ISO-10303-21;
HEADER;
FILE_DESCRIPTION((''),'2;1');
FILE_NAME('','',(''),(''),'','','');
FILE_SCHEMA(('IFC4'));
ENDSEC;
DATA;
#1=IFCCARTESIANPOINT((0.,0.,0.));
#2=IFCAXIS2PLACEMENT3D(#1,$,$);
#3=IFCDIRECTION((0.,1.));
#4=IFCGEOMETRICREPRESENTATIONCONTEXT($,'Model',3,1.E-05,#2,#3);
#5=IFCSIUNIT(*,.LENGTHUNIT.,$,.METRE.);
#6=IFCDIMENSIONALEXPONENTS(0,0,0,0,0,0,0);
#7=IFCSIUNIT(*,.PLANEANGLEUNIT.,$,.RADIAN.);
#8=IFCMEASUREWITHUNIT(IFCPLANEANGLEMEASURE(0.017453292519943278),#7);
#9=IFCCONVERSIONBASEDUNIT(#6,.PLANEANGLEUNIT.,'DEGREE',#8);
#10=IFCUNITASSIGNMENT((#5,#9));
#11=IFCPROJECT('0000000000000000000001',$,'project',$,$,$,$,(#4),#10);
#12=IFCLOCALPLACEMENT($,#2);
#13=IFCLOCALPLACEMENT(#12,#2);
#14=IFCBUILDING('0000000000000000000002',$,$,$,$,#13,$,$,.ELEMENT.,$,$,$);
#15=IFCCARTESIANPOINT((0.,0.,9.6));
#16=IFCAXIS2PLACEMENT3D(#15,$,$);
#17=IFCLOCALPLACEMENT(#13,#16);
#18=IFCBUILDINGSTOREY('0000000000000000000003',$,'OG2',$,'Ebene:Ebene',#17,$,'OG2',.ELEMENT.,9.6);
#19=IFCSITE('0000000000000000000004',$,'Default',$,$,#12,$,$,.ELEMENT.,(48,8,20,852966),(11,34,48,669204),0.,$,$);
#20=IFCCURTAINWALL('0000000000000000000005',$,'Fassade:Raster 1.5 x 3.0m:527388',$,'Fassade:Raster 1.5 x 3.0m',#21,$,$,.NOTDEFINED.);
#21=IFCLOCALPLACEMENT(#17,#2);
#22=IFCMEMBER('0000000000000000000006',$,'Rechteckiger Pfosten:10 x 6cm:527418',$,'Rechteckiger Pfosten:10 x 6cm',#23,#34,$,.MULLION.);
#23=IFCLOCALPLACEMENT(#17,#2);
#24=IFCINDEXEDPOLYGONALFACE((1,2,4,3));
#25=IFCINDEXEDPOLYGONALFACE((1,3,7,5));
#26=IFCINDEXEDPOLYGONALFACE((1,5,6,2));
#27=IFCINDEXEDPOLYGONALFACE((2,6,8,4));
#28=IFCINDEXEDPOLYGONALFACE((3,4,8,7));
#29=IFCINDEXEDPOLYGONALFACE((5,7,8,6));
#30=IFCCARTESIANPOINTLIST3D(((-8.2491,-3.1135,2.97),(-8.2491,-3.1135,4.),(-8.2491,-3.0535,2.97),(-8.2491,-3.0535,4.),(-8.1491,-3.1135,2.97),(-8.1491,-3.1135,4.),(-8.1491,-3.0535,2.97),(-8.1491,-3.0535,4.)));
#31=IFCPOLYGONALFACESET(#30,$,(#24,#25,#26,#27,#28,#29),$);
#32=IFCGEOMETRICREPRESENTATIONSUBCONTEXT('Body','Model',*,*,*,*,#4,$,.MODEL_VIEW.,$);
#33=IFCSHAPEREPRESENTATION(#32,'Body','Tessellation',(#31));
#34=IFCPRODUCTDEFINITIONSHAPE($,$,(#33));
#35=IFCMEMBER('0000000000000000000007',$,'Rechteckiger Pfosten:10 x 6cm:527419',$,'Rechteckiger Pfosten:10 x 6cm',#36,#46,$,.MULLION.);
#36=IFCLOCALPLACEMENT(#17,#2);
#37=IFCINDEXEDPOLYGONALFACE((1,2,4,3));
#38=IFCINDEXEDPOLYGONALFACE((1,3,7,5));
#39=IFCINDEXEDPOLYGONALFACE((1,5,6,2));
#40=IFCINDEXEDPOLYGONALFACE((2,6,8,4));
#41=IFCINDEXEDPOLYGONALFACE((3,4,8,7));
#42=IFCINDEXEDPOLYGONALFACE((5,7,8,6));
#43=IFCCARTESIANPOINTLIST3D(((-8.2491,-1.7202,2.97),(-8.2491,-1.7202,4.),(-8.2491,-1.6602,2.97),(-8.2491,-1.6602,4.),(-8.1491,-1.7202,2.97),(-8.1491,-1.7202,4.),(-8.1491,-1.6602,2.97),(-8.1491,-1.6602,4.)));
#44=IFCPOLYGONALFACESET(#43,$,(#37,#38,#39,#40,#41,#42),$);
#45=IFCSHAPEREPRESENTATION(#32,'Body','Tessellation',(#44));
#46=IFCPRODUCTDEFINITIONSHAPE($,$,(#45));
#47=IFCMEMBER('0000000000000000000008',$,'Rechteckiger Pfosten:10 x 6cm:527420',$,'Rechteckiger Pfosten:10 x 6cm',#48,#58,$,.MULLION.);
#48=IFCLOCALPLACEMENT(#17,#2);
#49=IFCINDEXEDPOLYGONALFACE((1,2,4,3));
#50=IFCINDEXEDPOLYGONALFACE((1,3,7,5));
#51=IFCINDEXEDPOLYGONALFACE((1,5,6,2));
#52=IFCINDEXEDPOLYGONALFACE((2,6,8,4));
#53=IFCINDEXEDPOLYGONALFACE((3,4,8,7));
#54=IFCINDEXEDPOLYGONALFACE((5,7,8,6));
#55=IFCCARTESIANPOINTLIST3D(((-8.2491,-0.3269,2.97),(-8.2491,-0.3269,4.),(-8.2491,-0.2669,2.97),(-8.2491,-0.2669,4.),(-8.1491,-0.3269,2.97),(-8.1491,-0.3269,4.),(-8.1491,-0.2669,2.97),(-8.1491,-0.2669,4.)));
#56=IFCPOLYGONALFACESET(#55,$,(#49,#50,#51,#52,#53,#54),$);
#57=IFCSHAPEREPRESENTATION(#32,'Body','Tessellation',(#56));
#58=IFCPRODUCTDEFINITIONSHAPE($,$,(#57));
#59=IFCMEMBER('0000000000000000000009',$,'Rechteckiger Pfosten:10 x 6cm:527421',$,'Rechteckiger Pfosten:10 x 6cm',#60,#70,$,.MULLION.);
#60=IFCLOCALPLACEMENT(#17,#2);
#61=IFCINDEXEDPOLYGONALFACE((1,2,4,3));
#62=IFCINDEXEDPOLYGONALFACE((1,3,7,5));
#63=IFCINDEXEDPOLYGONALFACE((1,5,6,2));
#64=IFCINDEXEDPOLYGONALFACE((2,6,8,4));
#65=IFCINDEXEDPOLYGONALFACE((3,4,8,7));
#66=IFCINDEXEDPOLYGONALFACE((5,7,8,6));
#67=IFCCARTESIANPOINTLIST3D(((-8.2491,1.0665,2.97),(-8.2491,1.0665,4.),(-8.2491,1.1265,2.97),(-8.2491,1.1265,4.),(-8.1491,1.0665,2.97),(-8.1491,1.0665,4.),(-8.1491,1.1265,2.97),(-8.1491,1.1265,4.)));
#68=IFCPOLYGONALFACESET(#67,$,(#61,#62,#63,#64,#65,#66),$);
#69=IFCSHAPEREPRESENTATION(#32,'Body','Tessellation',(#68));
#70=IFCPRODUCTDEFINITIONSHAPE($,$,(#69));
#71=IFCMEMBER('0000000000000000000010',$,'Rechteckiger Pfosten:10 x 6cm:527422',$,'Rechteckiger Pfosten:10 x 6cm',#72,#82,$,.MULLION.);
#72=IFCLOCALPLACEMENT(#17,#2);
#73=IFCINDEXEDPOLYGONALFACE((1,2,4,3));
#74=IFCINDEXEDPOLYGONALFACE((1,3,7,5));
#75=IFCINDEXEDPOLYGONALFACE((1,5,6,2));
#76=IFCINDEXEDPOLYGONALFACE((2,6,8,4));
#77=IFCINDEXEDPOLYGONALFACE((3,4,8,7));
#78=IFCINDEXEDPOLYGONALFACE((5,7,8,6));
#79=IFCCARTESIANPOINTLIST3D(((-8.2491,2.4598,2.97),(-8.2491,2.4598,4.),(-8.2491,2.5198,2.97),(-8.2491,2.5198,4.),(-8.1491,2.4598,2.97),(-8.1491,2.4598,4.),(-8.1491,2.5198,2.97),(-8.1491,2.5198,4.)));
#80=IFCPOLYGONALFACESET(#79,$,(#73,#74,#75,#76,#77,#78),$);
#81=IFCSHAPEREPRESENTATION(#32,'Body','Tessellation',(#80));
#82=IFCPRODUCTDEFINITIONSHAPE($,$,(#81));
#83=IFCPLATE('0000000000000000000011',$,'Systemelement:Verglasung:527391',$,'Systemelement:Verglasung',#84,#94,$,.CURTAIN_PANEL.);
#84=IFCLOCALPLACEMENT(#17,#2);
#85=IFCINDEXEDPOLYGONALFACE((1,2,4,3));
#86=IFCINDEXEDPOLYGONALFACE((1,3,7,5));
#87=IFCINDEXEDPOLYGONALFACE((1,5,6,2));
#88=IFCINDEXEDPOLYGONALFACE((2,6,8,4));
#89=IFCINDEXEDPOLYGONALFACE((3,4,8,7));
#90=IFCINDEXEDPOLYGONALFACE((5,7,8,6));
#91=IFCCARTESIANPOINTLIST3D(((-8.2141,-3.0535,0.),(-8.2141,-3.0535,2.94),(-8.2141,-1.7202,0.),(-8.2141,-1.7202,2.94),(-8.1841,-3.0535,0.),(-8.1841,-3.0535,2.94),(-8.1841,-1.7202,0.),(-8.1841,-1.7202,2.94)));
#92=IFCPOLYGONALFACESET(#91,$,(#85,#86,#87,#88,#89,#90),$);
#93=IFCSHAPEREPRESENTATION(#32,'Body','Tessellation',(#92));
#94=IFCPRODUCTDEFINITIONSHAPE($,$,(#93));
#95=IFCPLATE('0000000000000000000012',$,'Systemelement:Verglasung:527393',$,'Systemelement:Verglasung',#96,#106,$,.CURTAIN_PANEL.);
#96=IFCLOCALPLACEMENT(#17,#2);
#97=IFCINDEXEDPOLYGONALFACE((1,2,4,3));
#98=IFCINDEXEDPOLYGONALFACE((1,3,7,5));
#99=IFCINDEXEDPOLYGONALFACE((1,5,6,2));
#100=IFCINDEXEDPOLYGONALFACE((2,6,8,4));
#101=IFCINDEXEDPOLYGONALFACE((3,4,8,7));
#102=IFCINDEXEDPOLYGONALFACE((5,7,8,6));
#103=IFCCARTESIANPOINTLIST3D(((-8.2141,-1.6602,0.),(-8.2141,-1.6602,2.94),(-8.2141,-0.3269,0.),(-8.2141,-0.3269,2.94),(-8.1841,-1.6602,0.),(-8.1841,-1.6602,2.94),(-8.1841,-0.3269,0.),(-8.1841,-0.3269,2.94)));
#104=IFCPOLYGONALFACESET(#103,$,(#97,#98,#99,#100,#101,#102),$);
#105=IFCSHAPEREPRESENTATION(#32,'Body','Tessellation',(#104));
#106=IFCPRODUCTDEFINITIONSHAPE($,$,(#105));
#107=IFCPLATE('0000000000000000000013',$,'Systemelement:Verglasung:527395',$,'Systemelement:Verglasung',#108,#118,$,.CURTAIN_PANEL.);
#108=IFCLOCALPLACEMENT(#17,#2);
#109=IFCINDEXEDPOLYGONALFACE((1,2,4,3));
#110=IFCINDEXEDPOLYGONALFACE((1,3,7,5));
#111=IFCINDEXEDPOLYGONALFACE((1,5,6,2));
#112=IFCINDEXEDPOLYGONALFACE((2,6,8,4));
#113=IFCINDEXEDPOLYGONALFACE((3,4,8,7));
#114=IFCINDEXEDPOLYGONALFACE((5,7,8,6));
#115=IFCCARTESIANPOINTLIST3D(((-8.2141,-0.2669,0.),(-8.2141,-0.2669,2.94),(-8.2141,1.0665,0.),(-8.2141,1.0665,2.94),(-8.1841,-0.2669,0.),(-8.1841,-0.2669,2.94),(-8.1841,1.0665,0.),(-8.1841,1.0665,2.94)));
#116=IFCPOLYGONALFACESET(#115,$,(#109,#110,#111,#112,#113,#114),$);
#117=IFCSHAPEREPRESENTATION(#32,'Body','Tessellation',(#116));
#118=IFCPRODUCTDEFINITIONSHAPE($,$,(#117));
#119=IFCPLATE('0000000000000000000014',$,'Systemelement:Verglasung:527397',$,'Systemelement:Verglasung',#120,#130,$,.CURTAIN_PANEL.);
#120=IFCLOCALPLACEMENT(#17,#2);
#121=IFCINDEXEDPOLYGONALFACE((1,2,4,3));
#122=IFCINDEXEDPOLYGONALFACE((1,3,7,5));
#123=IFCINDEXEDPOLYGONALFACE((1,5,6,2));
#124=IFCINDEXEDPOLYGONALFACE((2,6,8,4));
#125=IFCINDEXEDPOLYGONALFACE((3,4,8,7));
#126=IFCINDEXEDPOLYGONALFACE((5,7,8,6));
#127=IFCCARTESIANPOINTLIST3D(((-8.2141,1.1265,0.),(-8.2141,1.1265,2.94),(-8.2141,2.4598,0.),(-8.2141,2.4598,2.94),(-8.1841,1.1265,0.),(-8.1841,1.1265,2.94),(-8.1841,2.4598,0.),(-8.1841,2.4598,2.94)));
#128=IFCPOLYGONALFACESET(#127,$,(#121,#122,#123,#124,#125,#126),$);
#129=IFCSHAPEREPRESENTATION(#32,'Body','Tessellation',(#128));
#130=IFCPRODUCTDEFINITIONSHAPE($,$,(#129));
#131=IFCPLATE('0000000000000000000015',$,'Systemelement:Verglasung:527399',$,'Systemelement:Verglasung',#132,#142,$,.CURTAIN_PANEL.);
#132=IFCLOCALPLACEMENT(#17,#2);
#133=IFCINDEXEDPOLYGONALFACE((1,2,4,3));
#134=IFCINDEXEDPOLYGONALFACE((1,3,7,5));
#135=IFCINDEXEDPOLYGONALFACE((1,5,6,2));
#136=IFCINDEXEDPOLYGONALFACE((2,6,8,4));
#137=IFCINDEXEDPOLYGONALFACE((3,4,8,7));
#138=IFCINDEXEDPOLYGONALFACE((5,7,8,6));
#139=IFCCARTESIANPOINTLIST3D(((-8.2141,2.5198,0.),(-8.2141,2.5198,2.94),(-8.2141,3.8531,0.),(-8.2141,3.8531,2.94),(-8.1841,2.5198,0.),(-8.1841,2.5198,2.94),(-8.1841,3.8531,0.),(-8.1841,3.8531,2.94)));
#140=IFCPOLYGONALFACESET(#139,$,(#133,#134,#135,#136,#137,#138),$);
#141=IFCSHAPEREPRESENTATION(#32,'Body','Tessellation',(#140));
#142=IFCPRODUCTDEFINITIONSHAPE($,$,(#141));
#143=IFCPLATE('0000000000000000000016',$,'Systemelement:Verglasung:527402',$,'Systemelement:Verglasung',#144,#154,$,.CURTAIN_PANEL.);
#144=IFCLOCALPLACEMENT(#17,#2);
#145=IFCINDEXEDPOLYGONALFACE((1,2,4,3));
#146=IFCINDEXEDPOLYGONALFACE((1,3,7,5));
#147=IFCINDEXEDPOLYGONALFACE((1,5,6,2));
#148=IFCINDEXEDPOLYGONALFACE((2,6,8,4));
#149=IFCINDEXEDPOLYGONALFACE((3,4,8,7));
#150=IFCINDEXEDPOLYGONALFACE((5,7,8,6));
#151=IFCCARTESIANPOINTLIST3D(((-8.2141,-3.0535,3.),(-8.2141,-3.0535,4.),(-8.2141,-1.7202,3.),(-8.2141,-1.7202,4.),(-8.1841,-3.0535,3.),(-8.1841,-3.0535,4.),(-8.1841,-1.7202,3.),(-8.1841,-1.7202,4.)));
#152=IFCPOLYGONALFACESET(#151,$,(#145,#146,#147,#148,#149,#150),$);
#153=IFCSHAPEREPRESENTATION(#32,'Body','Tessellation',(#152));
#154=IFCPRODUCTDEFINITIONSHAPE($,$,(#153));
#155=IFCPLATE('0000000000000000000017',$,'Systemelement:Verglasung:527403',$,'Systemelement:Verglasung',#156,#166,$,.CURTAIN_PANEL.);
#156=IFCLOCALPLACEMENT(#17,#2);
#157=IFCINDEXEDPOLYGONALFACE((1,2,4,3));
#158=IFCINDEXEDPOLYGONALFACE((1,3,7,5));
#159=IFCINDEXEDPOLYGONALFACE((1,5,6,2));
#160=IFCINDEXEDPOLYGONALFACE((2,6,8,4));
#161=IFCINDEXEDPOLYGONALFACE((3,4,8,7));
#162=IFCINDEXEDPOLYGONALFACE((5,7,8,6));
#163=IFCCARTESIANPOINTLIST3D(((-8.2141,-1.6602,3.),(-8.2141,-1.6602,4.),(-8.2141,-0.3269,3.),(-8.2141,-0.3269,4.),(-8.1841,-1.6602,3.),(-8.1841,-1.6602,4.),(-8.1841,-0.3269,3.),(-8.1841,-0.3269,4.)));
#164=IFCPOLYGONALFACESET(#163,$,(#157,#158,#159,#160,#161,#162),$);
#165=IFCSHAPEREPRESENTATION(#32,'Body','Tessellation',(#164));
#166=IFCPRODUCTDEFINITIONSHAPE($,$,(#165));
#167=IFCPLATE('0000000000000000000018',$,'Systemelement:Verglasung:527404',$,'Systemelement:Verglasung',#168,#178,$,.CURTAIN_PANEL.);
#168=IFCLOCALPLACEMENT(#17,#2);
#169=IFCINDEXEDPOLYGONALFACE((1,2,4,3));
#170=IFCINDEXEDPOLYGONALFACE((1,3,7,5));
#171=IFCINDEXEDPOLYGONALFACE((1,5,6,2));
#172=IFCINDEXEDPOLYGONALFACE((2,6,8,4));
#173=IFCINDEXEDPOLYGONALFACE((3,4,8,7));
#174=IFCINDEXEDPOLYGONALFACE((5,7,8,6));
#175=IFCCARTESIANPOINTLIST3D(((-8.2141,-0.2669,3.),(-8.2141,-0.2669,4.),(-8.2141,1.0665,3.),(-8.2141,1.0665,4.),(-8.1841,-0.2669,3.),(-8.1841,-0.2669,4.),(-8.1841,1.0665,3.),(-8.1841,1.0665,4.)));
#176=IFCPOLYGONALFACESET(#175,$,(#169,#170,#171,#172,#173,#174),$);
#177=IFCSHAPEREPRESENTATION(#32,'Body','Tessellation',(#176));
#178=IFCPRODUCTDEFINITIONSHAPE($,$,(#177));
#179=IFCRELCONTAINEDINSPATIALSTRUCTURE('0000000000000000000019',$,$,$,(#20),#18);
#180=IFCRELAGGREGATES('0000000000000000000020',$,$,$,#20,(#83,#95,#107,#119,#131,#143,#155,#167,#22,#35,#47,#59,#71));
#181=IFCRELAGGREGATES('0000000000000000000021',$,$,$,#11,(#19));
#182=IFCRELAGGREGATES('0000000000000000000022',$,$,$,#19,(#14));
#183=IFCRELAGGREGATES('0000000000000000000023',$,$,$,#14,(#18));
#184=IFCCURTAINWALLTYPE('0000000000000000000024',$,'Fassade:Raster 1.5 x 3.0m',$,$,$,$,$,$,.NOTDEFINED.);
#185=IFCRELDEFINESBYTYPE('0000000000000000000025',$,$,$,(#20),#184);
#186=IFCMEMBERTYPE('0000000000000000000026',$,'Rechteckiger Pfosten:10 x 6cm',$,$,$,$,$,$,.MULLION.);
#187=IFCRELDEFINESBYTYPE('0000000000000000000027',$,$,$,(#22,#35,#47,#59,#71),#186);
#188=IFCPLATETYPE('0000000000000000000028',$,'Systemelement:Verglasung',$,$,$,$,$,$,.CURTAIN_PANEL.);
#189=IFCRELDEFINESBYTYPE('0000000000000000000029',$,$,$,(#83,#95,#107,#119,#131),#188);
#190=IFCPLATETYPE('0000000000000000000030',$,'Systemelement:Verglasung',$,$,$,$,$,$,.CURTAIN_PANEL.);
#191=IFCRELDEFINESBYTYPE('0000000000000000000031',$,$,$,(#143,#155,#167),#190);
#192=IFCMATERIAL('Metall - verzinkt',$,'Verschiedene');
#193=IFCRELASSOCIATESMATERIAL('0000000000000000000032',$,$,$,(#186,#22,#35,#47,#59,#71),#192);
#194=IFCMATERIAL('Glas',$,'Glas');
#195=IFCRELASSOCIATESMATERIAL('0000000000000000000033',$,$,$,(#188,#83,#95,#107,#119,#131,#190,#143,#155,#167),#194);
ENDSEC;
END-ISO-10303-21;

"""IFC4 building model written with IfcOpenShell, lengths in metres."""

from ifc_helpers import new_model, entity, si_unit, converted_unit, direction, frame, origin, place, context, subcontext, project, spatial, indexed_curve, outline, extrude, source, transform, mapped, material, type_object, type_shapes, element, aggregate, save


model = new_model("IFC4")

# Units and contexts
model_context = context("Model", 3, precision=1e-05, world=origin(), true_north=direction((0.0, 1.0)))
body_context = subcontext(model_context, "Body", "Model", "MODEL_VIEW")
ifc_project = project(units=[si_unit("LENGTHUNIT", "METRE"), converted_unit("PLANEANGLEUNIT", "DEGREE", entity("IfcPlaneAngleMeasure", 0.017453292519943278), si_unit("PLANEANGLEUNIT", "RADIAN"), dimensions=[0, 0, 0, 0, 0, 0, 0])], contexts=[model_context])

# Site, building, storey
site_placement = place(None, origin())
site = spatial("IfcSite", under=ifc_project, at=site_placement, Name="Default", CompositionType="ELEMENT", RefLatitude=(48, 8, 20, 852966), RefLongitude=(11, 34, 48, 669204), RefElevation=0.0)
building_placement = place(site_placement, origin())
building = spatial("IfcBuilding", under=site, at=building_placement, CompositionType="ELEMENT")
storey_placement = place(building_placement, frame((0.0, 0.0, 9.6)))
storey = spatial("IfcBuildingStorey", under=building, at=storey_placement, Name="OG2", ObjectType="Ebene:Ebene", LongName="OG2", CompositionType="ELEMENT", Elevation=9.6)

# Curtain wall, members
curtain_wall_type = type_object("IfcCurtainWallType", Name="Fassade:Raster 1.5 x 3.0m", PredefinedType="NOTDEFINED")
curtain_wall_placement = place(storey_placement, frame((0.0, 0.0, -9.6)))
curtain_wall = element("IfcCurtainWall", 1, at=curtain_wall_placement, inside=storey, type_object=curtain_wall_type, Name="Fassade:Raster 1.5 x 3.0m:527388", ObjectType="Fassade:Raster 1.5 x 3.0m", PredefinedType="NOTDEFINED")
ifc_material_1 = material(Name="Metall - verzinkt", Category="Verschiedene")
member_type_1 = type_object("IfcMemberType", Name="Rechteckiger Pfosten:10 x 6cm", PredefinedType="MULLION", material=ifc_material_1)
shared_shape_1 = source(origin(), body_context, "Body", "SweptSolid", [
    extrude(outline(indexed_curve([(-0.03, -0.05), (0.03, -0.05), (0.03, 0.05), (-0.03, 0.05), (-0.03, -0.05)], self_intersect=False)), frame((0.0, 0.0, -1.03), z_axis=(0.0, 0.0, 1.0), x_axis=(-1.0, 0.0, 0.0)), (0.0, 0.0, 1.0), 1.03),
])
type_shapes(member_type_1, [shared_shape_1])
member_1_placement = place(curtain_wall_placement, frame((-8.1991, -3.0835, 12.57), z_axis=(0.0, 0.0, -1.0), x_axis=(0.0, 1.0, 0.0)))
member_1 = element("IfcMember", 2, at=member_1_placement, type_object=member_type_1, material=ifc_material_1, Name="Rechteckiger Pfosten:10 x 6cm:527418", ObjectType="Rechteckiger Pfosten:10 x 6cm", PredefinedType="MULLION", context=body_context, shape_type="MappedRepresentation", body=[
    mapped(shared_shape_1, transform((0.0, 0.0, 0.0), scale=1.0)),
])
member_2_placement = place(curtain_wall_placement, frame((-8.1991, -1.6902, 12.57), z_axis=(0.0, 0.0, -1.0), x_axis=(0.0, 1.0, 0.0)))
member_2 = element("IfcMember", 3, at=member_2_placement, type_object=member_type_1, material=ifc_material_1, Name="Rechteckiger Pfosten:10 x 6cm:527419", ObjectType="Rechteckiger Pfosten:10 x 6cm", PredefinedType="MULLION", context=body_context, shape_type="MappedRepresentation", body=[
    mapped(shared_shape_1, transform((0.0, 0.0, 0.0), scale=1.0)),
])
member_3_placement = place(curtain_wall_placement, frame((-8.1991, -0.2969, 12.57), z_axis=(0.0, 0.0, -1.0), x_axis=(0.0, 1.0, 0.0)))
member_3 = element("IfcMember", 4, at=member_3_placement, type_object=member_type_1, material=ifc_material_1, Name="Rechteckiger Pfosten:10 x 6cm:527420", ObjectType="Rechteckiger Pfosten:10 x 6cm", PredefinedType="MULLION", context=body_context, shape_type="MappedRepresentation", body=[
    mapped(shared_shape_1, transform((0.0, 0.0, 0.0), scale=1.0)),
])
member_4_placement = place(curtain_wall_placement, frame((-8.1991, 1.0965, 12.57), z_axis=(0.0, 0.0, -1.0), x_axis=(0.0, 1.0, 0.0)))
member_4 = element("IfcMember", 5, at=member_4_placement, type_object=member_type_1, material=ifc_material_1, Name="Rechteckiger Pfosten:10 x 6cm:527421", ObjectType="Rechteckiger Pfosten:10 x 6cm", PredefinedType="MULLION", context=body_context, shape_type="MappedRepresentation", body=[
    mapped(shared_shape_1, transform((0.0, 0.0, 0.0), scale=1.0)),
])
member_5_placement = place(curtain_wall_placement, frame((-8.1991, 2.4898, 12.57), z_axis=(0.0, 0.0, -1.0), x_axis=(0.0, 1.0, 0.0)))
member_5 = element("IfcMember", 6, at=member_5_placement, type_object=member_type_1, material=ifc_material_1, Name="Rechteckiger Pfosten:10 x 6cm:527422", ObjectType="Rechteckiger Pfosten:10 x 6cm", PredefinedType="MULLION", context=body_context, shape_type="MappedRepresentation", body=[
    mapped(shared_shape_1, transform((0.0, 0.0, 0.0), scale=1.0)),
])

# Plates
ifc_material_2 = material(Name="Glas", Category="Glas")
plate_type_1 = type_object("IfcPlateType", Name="Systemelement:Verglasung", PredefinedType="CURTAIN_PANEL", material=ifc_material_2)
shared_shape_2 = source(origin(), body_context, "Body", "SweptSolid", [
    extrude(outline(indexed_curve([(-0.015, -0.6667), (0.015, -0.6667), (0.015, 0.6667), (-0.015, 0.6667), (-0.015, -0.6667)], self_intersect=False)), frame((0.0, 0.0, 0.0), z_axis=(0.0, 0.0, 1.0), x_axis=(0.0, 1.0, 0.0)), (0.0, 0.0, 1.0), 2.94),
])
type_shapes(plate_type_1, [shared_shape_2])
plate_1_placement = place(curtain_wall_placement, frame((-8.1991, -2.3869, 9.6), z_axis=(0.0, 0.0, 1.0), x_axis=(0.0, 1.0, 0.0)))
plate_1 = element("IfcPlate", 7, at=plate_1_placement, type_object=plate_type_1, material=ifc_material_2, Name="Systemelement:Verglasung:527391", ObjectType="Systemelement:Verglasung", PredefinedType="CURTAIN_PANEL", context=body_context, shape_type="MappedRepresentation", body=[
    mapped(shared_shape_2, transform((0.0, 0.0, 0.0), scale=1.0)),
])
plate_2_placement = place(curtain_wall_placement, frame((-8.1991, -0.9935, 9.6), z_axis=(0.0, 0.0, 1.0), x_axis=(0.0, 1.0, 0.0)))
plate_2 = element("IfcPlate", 8, at=plate_2_placement, type_object=plate_type_1, material=ifc_material_2, Name="Systemelement:Verglasung:527393", ObjectType="Systemelement:Verglasung", PredefinedType="CURTAIN_PANEL", context=body_context, shape_type="MappedRepresentation", body=[
    mapped(shared_shape_2, transform((0.0, 0.0, 0.0), scale=1.0)),
])
plate_3_placement = place(curtain_wall_placement, frame((-8.1991, 0.3998, 9.6), z_axis=(0.0, 0.0, 1.0), x_axis=(0.0, 1.0, 0.0)))
plate_3 = element("IfcPlate", 9, at=plate_3_placement, type_object=plate_type_1, material=ifc_material_2, Name="Systemelement:Verglasung:527395", ObjectType="Systemelement:Verglasung", PredefinedType="CURTAIN_PANEL", context=body_context, shape_type="MappedRepresentation", body=[
    mapped(shared_shape_2, transform((0.0, 0.0, 0.0), scale=1.0)),
])
plate_4_placement = place(curtain_wall_placement, frame((-8.1991, 1.7931, 9.6), z_axis=(0.0, 0.0, 1.0), x_axis=(0.0, 1.0, 0.0)))
plate_4 = element("IfcPlate", 10, at=plate_4_placement, type_object=plate_type_1, material=ifc_material_2, Name="Systemelement:Verglasung:527397", ObjectType="Systemelement:Verglasung", PredefinedType="CURTAIN_PANEL", context=body_context, shape_type="MappedRepresentation", body=[
    mapped(shared_shape_2, transform((0.0, 0.0, 0.0), scale=1.0)),
])
plate_5_placement = place(curtain_wall_placement, frame((-8.1991, 3.1865, 9.6), z_axis=(0.0, 0.0, 1.0), x_axis=(0.0, 1.0, 0.0)))
plate_5 = element("IfcPlate", 11, at=plate_5_placement, type_object=plate_type_1, material=ifc_material_2, Name="Systemelement:Verglasung:527399", ObjectType="Systemelement:Verglasung", PredefinedType="CURTAIN_PANEL", context=body_context, shape_type="MappedRepresentation", body=[
    mapped(shared_shape_2, transform((0.0, 0.0, 0.0), scale=1.0)),
])
plate_type_2 = type_object("IfcPlateType", Name="Systemelement:Verglasung", PredefinedType="CURTAIN_PANEL", material=ifc_material_2)
shared_shape_3 = source(origin(), body_context, "Body", "SweptSolid", [
    extrude(outline(indexed_curve([(-0.015, -0.6667), (0.015, -0.6667), (0.015, 0.6667), (-0.015, 0.6667), (-0.015, -0.6667)], self_intersect=False)), frame((0.0, 0.0, 0.0), z_axis=(0.0, 0.0, 1.0), x_axis=(0.0, 1.0, 0.0)), (0.0, 0.0, 1.0), 1.0),
])
type_shapes(plate_type_2, [shared_shape_3])
plate_6_placement = place(curtain_wall_placement, frame((-8.1991, -2.3869, 12.6), z_axis=(0.0, 0.0, 1.0), x_axis=(0.0, 1.0, 0.0)))
plate_6 = element("IfcPlate", 12, at=plate_6_placement, type_object=plate_type_2, material=ifc_material_2, Name="Systemelement:Verglasung:527402", ObjectType="Systemelement:Verglasung", PredefinedType="CURTAIN_PANEL", context=body_context, shape_type="MappedRepresentation", body=[
    mapped(shared_shape_3, transform((0.0, 0.0, 0.0), scale=1.0)),
])
plate_7_placement = place(curtain_wall_placement, frame((-8.1991, -0.9935, 12.6), z_axis=(0.0, 0.0, 1.0), x_axis=(0.0, 1.0, 0.0)))
plate_7 = element("IfcPlate", 13, at=plate_7_placement, type_object=plate_type_2, material=ifc_material_2, Name="Systemelement:Verglasung:527403", ObjectType="Systemelement:Verglasung", PredefinedType="CURTAIN_PANEL", context=body_context, shape_type="MappedRepresentation", body=[
    mapped(shared_shape_3, transform((0.0, 0.0, 0.0), scale=1.0)),
])
plate_8_placement = place(curtain_wall_placement, frame((-8.1991, 0.3998, 12.6), z_axis=(0.0, 0.0, 1.0), x_axis=(0.0, 1.0, 0.0)))
plate_8 = element("IfcPlate", 14, at=plate_8_placement, type_object=plate_type_2, material=ifc_material_2, Name="Systemelement:Verglasung:527404", ObjectType="Systemelement:Verglasung", PredefinedType="CURTAIN_PANEL", context=body_context, shape_type="MappedRepresentation", body=[
    mapped(shared_shape_3, transform((0.0, 0.0, 0.0), scale=1.0)),
])
aggregate(curtain_wall, [plate_1, plate_2, plate_3, plate_4, plate_5, plate_6, plate_7, plate_8, member_1, member_2, member_3, member_4, member_5])

save(model, "model.ifc")
